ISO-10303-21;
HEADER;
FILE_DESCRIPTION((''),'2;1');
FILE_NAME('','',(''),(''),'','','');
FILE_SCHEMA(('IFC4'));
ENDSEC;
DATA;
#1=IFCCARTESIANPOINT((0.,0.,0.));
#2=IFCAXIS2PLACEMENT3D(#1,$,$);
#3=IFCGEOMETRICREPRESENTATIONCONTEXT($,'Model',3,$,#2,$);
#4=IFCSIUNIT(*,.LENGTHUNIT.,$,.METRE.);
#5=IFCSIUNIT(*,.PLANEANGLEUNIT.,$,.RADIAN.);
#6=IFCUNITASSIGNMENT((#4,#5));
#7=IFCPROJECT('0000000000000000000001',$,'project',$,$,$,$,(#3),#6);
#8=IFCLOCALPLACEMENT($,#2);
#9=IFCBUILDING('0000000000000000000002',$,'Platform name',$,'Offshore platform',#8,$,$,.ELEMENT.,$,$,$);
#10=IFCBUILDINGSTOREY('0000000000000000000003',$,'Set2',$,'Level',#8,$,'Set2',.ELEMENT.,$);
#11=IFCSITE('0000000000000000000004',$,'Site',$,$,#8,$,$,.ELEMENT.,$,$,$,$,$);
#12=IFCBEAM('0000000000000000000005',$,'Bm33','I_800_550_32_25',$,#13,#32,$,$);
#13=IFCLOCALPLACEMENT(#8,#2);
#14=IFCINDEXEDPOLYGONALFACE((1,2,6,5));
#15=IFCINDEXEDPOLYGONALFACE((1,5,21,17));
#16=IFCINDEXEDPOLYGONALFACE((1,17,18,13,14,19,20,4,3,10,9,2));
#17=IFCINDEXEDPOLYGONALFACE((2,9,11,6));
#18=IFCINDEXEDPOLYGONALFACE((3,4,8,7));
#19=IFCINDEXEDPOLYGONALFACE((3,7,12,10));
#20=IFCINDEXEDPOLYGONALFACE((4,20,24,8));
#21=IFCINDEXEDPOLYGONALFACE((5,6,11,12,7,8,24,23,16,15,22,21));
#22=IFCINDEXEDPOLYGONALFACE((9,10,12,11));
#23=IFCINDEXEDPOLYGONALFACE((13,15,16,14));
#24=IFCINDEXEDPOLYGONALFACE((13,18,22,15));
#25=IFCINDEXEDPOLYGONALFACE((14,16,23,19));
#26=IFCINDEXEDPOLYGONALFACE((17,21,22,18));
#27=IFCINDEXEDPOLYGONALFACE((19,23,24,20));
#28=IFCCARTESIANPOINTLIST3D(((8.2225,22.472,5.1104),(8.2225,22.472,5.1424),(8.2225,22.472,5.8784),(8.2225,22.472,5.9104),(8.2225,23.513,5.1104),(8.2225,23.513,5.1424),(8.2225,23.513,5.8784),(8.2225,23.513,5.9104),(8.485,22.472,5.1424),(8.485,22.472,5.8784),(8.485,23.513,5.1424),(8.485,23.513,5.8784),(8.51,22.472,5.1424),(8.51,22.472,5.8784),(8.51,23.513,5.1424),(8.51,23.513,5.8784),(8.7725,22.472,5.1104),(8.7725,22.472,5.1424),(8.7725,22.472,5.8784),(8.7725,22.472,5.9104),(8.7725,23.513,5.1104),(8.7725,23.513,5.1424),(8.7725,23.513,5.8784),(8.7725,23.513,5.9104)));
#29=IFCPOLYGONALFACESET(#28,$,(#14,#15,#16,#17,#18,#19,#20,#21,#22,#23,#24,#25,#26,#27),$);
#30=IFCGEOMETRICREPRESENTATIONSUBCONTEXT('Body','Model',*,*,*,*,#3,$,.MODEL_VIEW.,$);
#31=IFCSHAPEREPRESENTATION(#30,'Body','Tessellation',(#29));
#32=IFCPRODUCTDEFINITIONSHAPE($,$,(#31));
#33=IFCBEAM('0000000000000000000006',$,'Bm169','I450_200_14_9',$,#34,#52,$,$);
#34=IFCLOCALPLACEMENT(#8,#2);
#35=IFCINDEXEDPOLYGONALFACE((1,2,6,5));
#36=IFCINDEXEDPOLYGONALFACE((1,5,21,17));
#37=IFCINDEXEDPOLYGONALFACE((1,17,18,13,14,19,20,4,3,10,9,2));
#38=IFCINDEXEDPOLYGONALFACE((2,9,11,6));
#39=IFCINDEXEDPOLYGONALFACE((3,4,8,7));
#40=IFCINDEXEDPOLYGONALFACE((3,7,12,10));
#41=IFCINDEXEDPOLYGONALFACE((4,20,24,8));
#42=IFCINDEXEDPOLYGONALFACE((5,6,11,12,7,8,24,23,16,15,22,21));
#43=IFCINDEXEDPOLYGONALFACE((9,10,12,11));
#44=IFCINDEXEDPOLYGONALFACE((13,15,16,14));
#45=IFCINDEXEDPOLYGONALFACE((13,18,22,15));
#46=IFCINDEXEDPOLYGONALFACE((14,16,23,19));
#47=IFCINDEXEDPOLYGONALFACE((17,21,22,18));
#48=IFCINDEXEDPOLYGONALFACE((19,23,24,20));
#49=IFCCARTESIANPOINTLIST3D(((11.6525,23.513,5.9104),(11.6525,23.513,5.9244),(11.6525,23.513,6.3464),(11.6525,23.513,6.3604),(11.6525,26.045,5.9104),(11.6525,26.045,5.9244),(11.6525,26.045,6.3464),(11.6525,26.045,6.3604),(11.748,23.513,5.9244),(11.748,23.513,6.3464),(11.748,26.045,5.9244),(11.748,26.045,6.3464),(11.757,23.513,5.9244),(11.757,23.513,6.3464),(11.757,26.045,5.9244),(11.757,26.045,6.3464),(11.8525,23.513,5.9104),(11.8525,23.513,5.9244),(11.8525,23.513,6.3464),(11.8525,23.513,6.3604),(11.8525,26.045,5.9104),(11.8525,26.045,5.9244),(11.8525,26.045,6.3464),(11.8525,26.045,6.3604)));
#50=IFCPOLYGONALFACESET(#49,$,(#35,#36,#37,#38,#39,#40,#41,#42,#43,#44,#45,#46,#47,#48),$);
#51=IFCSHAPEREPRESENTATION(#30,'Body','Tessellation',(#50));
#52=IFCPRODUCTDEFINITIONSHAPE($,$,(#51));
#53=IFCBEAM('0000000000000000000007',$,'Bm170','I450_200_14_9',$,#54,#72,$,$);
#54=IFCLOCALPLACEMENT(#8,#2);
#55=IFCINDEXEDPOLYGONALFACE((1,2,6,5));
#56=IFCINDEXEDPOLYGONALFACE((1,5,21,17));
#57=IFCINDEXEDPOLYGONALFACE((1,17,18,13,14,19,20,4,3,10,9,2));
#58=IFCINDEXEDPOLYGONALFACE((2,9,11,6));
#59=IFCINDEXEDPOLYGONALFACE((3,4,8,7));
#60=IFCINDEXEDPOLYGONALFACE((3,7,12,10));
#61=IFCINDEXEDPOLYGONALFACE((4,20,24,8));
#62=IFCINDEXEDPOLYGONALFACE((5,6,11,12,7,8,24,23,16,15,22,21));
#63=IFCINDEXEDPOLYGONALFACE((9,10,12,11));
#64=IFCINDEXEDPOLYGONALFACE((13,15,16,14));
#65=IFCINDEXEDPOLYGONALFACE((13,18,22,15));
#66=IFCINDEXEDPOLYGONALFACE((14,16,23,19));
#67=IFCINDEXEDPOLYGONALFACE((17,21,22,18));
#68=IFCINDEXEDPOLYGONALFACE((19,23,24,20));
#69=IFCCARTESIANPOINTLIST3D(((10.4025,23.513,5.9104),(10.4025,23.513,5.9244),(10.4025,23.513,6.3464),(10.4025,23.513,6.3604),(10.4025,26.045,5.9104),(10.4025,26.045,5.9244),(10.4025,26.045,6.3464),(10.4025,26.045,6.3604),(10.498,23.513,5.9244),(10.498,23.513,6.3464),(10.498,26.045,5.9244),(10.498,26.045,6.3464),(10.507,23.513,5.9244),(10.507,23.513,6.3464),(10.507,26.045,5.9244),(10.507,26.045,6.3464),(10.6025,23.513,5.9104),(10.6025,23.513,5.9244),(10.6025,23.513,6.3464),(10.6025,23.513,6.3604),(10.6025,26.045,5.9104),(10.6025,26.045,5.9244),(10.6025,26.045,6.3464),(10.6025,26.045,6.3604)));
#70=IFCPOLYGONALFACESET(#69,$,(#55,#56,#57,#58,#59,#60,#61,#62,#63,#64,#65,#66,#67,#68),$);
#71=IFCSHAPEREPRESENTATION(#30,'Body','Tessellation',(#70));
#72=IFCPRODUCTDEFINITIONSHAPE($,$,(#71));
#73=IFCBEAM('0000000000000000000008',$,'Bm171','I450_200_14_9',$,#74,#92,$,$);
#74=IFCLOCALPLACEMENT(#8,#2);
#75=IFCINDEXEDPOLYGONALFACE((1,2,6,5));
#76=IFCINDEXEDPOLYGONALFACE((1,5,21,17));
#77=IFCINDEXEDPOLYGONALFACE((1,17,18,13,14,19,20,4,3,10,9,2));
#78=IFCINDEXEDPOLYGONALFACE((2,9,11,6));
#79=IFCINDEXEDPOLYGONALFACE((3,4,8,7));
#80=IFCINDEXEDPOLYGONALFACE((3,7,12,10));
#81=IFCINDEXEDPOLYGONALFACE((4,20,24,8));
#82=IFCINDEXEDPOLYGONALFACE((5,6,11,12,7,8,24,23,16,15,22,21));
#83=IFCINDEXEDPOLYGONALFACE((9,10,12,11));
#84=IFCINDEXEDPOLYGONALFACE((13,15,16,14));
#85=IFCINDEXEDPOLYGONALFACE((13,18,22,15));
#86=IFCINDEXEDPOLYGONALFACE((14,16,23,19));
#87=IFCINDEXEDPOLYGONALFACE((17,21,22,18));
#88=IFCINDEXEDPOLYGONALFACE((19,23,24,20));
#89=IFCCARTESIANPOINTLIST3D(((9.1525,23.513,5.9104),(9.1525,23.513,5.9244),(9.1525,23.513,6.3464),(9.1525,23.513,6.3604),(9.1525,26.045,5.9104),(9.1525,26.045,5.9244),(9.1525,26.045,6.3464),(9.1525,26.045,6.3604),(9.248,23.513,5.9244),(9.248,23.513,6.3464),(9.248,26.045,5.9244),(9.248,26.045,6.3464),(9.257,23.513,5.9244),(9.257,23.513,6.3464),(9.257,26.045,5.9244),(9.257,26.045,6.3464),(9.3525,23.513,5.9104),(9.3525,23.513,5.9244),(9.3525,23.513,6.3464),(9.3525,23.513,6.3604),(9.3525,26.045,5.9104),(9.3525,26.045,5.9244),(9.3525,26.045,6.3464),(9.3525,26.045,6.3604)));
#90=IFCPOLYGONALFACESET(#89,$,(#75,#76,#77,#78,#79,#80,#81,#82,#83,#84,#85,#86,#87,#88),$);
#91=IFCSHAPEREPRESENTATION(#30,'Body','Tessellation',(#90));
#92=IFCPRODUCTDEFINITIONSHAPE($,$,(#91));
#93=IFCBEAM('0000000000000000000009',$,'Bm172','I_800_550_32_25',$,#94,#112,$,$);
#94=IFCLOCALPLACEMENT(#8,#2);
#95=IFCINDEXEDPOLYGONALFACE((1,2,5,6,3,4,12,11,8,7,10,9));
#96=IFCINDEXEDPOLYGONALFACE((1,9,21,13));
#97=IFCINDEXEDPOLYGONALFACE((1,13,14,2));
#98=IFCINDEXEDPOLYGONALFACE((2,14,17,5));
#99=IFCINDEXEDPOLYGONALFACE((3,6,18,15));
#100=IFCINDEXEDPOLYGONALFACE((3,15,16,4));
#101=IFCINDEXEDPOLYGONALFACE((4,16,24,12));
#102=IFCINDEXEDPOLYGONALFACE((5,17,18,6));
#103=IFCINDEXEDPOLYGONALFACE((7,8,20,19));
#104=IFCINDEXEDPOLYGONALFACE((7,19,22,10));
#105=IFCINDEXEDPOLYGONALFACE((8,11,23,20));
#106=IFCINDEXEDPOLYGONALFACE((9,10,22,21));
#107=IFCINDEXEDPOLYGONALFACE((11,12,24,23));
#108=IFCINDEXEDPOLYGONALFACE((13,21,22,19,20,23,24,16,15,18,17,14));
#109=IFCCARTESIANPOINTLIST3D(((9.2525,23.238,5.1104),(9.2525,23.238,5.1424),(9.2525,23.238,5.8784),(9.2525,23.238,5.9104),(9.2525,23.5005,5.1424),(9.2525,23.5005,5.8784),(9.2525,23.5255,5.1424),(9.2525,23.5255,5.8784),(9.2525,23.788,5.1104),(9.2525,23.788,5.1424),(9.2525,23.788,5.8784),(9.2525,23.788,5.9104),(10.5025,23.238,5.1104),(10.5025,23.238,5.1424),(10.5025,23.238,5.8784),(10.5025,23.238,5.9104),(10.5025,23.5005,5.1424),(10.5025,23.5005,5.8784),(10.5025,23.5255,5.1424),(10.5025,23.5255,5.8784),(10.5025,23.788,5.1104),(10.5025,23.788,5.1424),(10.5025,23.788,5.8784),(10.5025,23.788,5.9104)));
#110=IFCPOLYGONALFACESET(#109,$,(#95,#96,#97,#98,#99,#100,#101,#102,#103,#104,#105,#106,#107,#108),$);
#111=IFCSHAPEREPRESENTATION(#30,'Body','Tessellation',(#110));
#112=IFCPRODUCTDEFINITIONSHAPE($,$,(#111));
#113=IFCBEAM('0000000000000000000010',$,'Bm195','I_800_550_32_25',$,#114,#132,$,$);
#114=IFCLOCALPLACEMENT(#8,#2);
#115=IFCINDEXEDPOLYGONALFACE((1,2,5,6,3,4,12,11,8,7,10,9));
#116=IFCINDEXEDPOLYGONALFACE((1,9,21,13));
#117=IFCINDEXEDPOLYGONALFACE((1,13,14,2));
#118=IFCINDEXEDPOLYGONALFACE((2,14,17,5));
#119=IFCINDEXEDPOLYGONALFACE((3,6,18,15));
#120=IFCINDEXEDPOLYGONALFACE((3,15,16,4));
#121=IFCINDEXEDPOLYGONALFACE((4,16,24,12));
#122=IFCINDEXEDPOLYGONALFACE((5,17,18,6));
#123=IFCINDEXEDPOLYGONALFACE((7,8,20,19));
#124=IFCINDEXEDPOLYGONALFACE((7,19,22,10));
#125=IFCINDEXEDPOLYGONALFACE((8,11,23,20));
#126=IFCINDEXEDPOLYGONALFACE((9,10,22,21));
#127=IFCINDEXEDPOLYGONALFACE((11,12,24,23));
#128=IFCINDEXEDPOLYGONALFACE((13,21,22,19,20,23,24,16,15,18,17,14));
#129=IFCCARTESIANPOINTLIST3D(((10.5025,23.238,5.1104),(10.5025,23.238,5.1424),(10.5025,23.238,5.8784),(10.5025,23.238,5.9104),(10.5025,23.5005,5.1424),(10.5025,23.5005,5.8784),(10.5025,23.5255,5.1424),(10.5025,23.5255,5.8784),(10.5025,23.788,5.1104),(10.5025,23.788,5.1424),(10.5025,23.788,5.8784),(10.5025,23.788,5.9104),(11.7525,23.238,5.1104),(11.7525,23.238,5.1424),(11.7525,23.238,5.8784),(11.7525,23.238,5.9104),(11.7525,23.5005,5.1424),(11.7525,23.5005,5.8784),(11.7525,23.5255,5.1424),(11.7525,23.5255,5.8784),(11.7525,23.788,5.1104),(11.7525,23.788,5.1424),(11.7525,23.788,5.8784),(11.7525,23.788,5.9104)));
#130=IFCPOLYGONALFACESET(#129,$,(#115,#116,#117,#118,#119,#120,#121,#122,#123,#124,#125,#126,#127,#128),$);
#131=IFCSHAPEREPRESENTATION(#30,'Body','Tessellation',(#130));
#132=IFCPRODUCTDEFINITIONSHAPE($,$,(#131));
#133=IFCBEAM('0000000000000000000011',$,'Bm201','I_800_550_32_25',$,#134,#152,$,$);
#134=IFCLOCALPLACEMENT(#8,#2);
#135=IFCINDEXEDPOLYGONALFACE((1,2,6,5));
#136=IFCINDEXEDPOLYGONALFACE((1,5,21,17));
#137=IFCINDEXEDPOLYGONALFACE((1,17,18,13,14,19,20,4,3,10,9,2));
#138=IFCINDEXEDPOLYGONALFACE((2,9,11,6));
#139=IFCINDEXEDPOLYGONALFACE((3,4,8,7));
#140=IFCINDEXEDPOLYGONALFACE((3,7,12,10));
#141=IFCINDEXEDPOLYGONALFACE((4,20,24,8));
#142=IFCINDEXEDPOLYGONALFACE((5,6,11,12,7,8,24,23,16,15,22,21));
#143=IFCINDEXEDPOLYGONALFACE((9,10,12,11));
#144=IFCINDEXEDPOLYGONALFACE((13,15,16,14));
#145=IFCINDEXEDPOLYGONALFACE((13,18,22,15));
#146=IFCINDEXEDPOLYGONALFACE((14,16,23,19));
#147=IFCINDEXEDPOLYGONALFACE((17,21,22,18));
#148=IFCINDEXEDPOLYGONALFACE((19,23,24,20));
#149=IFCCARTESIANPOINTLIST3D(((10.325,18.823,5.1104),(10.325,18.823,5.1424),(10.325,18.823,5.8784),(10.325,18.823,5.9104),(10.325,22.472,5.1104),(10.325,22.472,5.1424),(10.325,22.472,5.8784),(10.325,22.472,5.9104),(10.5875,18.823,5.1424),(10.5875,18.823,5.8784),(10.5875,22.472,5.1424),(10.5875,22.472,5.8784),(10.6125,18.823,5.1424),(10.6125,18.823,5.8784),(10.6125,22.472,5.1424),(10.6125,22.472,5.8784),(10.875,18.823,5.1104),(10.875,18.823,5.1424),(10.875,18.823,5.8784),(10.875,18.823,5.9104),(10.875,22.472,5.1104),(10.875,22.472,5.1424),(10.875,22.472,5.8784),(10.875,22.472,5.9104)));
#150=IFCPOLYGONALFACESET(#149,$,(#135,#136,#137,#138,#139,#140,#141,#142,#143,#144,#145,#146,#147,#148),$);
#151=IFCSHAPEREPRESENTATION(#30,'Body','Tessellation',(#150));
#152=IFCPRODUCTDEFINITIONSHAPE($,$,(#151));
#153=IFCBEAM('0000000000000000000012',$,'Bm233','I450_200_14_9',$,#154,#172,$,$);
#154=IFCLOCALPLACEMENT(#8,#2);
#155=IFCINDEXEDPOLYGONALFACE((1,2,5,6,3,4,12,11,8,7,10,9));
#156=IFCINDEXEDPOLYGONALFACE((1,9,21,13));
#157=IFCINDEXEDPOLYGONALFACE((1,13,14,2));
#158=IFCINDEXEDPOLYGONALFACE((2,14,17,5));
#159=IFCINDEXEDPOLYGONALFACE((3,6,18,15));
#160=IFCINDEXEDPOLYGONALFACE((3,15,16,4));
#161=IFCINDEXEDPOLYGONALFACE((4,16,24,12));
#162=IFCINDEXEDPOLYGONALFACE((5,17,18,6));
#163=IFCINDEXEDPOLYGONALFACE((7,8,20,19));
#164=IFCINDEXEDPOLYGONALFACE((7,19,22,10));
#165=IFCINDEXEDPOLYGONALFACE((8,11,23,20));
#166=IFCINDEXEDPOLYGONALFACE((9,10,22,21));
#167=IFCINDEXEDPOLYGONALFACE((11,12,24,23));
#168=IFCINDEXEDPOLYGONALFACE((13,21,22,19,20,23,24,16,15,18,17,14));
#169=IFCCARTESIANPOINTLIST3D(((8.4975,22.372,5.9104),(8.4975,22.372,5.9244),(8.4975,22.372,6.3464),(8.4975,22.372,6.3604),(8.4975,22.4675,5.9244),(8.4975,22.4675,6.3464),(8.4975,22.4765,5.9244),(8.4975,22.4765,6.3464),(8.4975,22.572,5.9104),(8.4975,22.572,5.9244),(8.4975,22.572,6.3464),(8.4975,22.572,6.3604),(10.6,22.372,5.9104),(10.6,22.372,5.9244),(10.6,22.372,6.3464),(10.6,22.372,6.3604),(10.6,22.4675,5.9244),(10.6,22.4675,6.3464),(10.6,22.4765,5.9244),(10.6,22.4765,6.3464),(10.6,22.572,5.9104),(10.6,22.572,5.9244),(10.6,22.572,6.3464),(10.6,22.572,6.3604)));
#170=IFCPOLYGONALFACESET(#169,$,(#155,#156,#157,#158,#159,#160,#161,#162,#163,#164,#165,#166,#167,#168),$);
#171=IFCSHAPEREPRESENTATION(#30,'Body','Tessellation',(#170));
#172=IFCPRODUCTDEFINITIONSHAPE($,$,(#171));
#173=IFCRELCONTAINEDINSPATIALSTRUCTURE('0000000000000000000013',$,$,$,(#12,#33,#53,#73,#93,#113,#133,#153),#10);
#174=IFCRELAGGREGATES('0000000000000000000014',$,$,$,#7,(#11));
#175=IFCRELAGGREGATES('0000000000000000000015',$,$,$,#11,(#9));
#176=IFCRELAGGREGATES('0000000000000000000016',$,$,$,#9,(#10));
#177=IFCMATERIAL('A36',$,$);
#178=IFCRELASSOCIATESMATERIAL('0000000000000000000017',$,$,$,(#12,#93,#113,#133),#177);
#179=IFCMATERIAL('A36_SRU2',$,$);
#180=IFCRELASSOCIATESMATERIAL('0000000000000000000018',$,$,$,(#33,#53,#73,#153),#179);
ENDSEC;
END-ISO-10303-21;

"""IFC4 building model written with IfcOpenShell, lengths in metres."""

from ifc_helpers import new_model, si_unit, frame, origin, origin_2d, place, context, subcontext, project, spatial, i_section, extrude, source, transform, mapped, material, element, save


model = new_model("IFC4")

# Units and contexts
model_context = context("Model", 3, world=origin())
body_context = subcontext(model_context, "Body", "Model", "MODEL_VIEW")
ifc_project = project(units=[si_unit("LENGTHUNIT", "METRE"), si_unit("PLANEANGLEUNIT", "RADIAN")], contexts=[model_context])

# Site, building, storey
placement_1 = place(None, origin())
site = spatial("IfcSite", under=ifc_project, at=placement_1, Name="Site", CompositionType="ELEMENT")
building = spatial("IfcBuilding", under=site, at=placement_1, Name="Platform name", ObjectType="Offshore platform", CompositionType="ELEMENT")
storey = spatial("IfcBuildingStorey", under=building, at=placement_1, Name="Set2", ObjectType="Level", LongName="Set2", CompositionType="ELEMENT")

# Beams
ifc_material_1 = material(Name="A36_SRU2")
ifc_material_2 = material(Name="A36")
shared_shape_1 = source(origin(), body_context, "Body", "SweptSolid", [
    extrude(i_section(OverallWidth=0.55, OverallDepth=0.8, WebThickness=0.025, FlangeThickness=0.032, FilletRadius=0.0, at=origin_2d()), frame((0.0, 0.0, 0.0), z_axis=(0.0, -1.0, 0.0), x_axis=(1.0, 0.0, 0.0)), (0.0, 0.0, 1.0), 1.041),
])
placement_2 = place(None, origin())
placement_3 = place(placement_2, origin())
placement_4 = place(placement_3, origin())
beam_1_placement = place(placement_4, frame((8.4975, 23.513, 5.5104)))
element("IfcBeam", 1, at=beam_1_placement, inside=storey, material=ifc_material_2, Name="Bm33", Description="I_800_550_32_25", context=body_context, shape_type="MappedRepresentation", body=[
    mapped(shared_shape_1, transform((0.0, 0.0, 0.0), scale=1.0)),
])
shared_shape_2 = source(origin(), body_context, "Body", "SweptSolid", [
    extrude(i_section(OverallWidth=0.2, OverallDepth=0.45, WebThickness=0.009, FlangeThickness=0.014, FilletRadius=0.0, at=origin_2d()), frame((0.0, 0.0, 0.0), z_axis=(0.0, 1.0, 0.0), x_axis=(-1.0, 0.0, 0.0)), (0.0, 0.0, 1.0), 2.532),
])
placement_5 = place(None, origin())
placement_6 = place(placement_5, origin())
placement_7 = place(placement_6, origin())
beam_2_placement = place(placement_7, frame((11.7525, 23.513, 6.1354)))
element("IfcBeam", 2, at=beam_2_placement, inside=storey, material=ifc_material_1, Name="Bm169", Description="I450_200_14_9", context=body_context, shape_type="MappedRepresentation", body=[
    mapped(shared_shape_2, transform((0.0, 0.0, 0.0), scale=1.0)),
])
shared_shape_3 = source(origin(), body_context, "Body", "SweptSolid", [
    extrude(i_section(OverallWidth=0.2, OverallDepth=0.45, WebThickness=0.009, FlangeThickness=0.014, FilletRadius=0.0, at=origin_2d()), frame((0.0, 0.0, 0.0), z_axis=(0.0, 1.0, 0.0), x_axis=(-1.0, 0.0, 0.0)), (0.0, 0.0, 1.0), 2.532),
])
placement_8 = place(None, origin())
placement_9 = place(placement_8, origin())
placement_10 = place(placement_9, origin())
beam_3_placement = place(placement_10, frame((10.5025, 23.513, 6.1354)))
element("IfcBeam", 3, at=beam_3_placement, inside=storey, material=ifc_material_1, Name="Bm170", Description="I450_200_14_9", context=body_context, shape_type="MappedRepresentation", body=[
    mapped(shared_shape_3, transform((0.0, 0.0, 0.0), scale=1.0)),
])
shared_shape_4 = source(origin(), body_context, "Body", "SweptSolid", [
    extrude(i_section(OverallWidth=0.2, OverallDepth=0.45, WebThickness=0.009, FlangeThickness=0.014, FilletRadius=0.0, at=origin_2d()), frame((0.0, 0.0, 0.0), z_axis=(0.0, 1.0, 0.0), x_axis=(-1.0, 0.0, 0.0)), (0.0, 0.0, 1.0), 2.532),
])
placement_11 = place(None, origin())
placement_12 = place(placement_11, origin())
placement_13 = place(placement_12, origin())
beam_4_placement = place(placement_13, frame((9.2525, 23.513, 6.1354)))
element("IfcBeam", 4, at=beam_4_placement, inside=storey, material=ifc_material_1, Name="Bm171", Description="I450_200_14_9", context=body_context, shape_type="MappedRepresentation", body=[
    mapped(shared_shape_4, transform((0.0, 0.0, 0.0), scale=1.0)),
])
shared_shape_5 = source(origin(), body_context, "Body", "SweptSolid", [
    extrude(i_section(OverallWidth=0.55, OverallDepth=0.8, WebThickness=0.025, FlangeThickness=0.032, FilletRadius=0.0, at=origin_2d()), frame((0.0, 0.0, 0.0), z_axis=(1.0, 0.0, 0.0), x_axis=(0.0, 1.0, 0.0)), (0.0, 0.0, 1.0), 1.25),
])
placement_14 = place(None, origin())
placement_15 = place(placement_14, origin())
placement_16 = place(placement_15, origin())
beam_5_placement = place(placement_16, frame((9.2525, 23.513, 5.5104)))
element("IfcBeam", 5, at=beam_5_placement, inside=storey, material=ifc_material_2, Name="Bm172", Description="I_800_550_32_25", context=body_context, shape_type="MappedRepresentation", body=[
    mapped(shared_shape_5, transform((0.0, 0.0, 0.0), scale=1.0)),
])
shared_shape_6 = source(origin(), body_context, "Body", "SweptSolid", [
    extrude(i_section(OverallWidth=0.55, OverallDepth=0.8, WebThickness=0.025, FlangeThickness=0.032, FilletRadius=0.0, at=origin_2d()), frame((0.0, 0.0, 0.0), z_axis=(1.0, 0.0, 0.0), x_axis=(0.0, 1.0, 0.0)), (0.0, 0.0, 1.0), 1.25),
])
placement_17 = place(None, origin())
placement_18 = place(placement_17, origin())
placement_19 = place(placement_18, origin())
beam_6_placement = place(placement_19, frame((10.5025, 23.513, 5.5104)))
element("IfcBeam", 6, at=beam_6_placement, inside=storey, material=ifc_material_2, Name="Bm195", Description="I_800_550_32_25", context=body_context, shape_type="MappedRepresentation", body=[
    mapped(shared_shape_6, transform((0.0, 0.0, 0.0), scale=1.0)),
])
shared_shape_7 = source(origin(), body_context, "Body", "SweptSolid", [
    extrude(i_section(OverallWidth=0.55, OverallDepth=0.8, WebThickness=0.025, FlangeThickness=0.032, FilletRadius=0.0, at=origin_2d()), frame((0.0, 0.0, 0.0), z_axis=(0.0, -1.0, 0.0), x_axis=(1.0, 0.0, 0.0)), (0.0, 0.0, 1.0), 3.649),
])
placement_20 = place(None, origin())
placement_21 = place(placement_20, origin())
placement_22 = place(placement_21, origin())
beam_7_placement = place(placement_22, frame((10.6, 22.472, 5.5104)))
element("IfcBeam", 7, at=beam_7_placement, inside=storey, material=ifc_material_2, Name="Bm201", Description="I_800_550_32_25", context=body_context, shape_type="MappedRepresentation", body=[
    mapped(shared_shape_7, transform((0.0, 0.0, 0.0), scale=1.0)),
])
shared_shape_8 = source(origin(), body_context, "Body", "SweptSolid", [
    extrude(i_section(OverallWidth=0.2, OverallDepth=0.45, WebThickness=0.009, FlangeThickness=0.014, FilletRadius=0.0, at=origin_2d()), frame((0.0, 0.0, 0.0), z_axis=(-1.0, 0.0, 0.0), x_axis=(0.0, -1.0, 0.0)), (0.0, 0.0, 1.0), 2.1025),
])
placement_23 = place(None, origin())
placement_24 = place(placement_23, origin())
placement_25 = place(placement_24, origin())
beam_8_placement = place(placement_25, frame((10.6, 22.472, 6.1354)))
element("IfcBeam", 8, at=beam_8_placement, inside=storey, material=ifc_material_1, Name="Bm233", Description="I450_200_14_9", context=body_context, shape_type="MappedRepresentation", body=[
    mapped(shared_shape_8, transform((0.0, 0.0, 0.0), scale=1.0)),
])

save(model, "model.ifc")
